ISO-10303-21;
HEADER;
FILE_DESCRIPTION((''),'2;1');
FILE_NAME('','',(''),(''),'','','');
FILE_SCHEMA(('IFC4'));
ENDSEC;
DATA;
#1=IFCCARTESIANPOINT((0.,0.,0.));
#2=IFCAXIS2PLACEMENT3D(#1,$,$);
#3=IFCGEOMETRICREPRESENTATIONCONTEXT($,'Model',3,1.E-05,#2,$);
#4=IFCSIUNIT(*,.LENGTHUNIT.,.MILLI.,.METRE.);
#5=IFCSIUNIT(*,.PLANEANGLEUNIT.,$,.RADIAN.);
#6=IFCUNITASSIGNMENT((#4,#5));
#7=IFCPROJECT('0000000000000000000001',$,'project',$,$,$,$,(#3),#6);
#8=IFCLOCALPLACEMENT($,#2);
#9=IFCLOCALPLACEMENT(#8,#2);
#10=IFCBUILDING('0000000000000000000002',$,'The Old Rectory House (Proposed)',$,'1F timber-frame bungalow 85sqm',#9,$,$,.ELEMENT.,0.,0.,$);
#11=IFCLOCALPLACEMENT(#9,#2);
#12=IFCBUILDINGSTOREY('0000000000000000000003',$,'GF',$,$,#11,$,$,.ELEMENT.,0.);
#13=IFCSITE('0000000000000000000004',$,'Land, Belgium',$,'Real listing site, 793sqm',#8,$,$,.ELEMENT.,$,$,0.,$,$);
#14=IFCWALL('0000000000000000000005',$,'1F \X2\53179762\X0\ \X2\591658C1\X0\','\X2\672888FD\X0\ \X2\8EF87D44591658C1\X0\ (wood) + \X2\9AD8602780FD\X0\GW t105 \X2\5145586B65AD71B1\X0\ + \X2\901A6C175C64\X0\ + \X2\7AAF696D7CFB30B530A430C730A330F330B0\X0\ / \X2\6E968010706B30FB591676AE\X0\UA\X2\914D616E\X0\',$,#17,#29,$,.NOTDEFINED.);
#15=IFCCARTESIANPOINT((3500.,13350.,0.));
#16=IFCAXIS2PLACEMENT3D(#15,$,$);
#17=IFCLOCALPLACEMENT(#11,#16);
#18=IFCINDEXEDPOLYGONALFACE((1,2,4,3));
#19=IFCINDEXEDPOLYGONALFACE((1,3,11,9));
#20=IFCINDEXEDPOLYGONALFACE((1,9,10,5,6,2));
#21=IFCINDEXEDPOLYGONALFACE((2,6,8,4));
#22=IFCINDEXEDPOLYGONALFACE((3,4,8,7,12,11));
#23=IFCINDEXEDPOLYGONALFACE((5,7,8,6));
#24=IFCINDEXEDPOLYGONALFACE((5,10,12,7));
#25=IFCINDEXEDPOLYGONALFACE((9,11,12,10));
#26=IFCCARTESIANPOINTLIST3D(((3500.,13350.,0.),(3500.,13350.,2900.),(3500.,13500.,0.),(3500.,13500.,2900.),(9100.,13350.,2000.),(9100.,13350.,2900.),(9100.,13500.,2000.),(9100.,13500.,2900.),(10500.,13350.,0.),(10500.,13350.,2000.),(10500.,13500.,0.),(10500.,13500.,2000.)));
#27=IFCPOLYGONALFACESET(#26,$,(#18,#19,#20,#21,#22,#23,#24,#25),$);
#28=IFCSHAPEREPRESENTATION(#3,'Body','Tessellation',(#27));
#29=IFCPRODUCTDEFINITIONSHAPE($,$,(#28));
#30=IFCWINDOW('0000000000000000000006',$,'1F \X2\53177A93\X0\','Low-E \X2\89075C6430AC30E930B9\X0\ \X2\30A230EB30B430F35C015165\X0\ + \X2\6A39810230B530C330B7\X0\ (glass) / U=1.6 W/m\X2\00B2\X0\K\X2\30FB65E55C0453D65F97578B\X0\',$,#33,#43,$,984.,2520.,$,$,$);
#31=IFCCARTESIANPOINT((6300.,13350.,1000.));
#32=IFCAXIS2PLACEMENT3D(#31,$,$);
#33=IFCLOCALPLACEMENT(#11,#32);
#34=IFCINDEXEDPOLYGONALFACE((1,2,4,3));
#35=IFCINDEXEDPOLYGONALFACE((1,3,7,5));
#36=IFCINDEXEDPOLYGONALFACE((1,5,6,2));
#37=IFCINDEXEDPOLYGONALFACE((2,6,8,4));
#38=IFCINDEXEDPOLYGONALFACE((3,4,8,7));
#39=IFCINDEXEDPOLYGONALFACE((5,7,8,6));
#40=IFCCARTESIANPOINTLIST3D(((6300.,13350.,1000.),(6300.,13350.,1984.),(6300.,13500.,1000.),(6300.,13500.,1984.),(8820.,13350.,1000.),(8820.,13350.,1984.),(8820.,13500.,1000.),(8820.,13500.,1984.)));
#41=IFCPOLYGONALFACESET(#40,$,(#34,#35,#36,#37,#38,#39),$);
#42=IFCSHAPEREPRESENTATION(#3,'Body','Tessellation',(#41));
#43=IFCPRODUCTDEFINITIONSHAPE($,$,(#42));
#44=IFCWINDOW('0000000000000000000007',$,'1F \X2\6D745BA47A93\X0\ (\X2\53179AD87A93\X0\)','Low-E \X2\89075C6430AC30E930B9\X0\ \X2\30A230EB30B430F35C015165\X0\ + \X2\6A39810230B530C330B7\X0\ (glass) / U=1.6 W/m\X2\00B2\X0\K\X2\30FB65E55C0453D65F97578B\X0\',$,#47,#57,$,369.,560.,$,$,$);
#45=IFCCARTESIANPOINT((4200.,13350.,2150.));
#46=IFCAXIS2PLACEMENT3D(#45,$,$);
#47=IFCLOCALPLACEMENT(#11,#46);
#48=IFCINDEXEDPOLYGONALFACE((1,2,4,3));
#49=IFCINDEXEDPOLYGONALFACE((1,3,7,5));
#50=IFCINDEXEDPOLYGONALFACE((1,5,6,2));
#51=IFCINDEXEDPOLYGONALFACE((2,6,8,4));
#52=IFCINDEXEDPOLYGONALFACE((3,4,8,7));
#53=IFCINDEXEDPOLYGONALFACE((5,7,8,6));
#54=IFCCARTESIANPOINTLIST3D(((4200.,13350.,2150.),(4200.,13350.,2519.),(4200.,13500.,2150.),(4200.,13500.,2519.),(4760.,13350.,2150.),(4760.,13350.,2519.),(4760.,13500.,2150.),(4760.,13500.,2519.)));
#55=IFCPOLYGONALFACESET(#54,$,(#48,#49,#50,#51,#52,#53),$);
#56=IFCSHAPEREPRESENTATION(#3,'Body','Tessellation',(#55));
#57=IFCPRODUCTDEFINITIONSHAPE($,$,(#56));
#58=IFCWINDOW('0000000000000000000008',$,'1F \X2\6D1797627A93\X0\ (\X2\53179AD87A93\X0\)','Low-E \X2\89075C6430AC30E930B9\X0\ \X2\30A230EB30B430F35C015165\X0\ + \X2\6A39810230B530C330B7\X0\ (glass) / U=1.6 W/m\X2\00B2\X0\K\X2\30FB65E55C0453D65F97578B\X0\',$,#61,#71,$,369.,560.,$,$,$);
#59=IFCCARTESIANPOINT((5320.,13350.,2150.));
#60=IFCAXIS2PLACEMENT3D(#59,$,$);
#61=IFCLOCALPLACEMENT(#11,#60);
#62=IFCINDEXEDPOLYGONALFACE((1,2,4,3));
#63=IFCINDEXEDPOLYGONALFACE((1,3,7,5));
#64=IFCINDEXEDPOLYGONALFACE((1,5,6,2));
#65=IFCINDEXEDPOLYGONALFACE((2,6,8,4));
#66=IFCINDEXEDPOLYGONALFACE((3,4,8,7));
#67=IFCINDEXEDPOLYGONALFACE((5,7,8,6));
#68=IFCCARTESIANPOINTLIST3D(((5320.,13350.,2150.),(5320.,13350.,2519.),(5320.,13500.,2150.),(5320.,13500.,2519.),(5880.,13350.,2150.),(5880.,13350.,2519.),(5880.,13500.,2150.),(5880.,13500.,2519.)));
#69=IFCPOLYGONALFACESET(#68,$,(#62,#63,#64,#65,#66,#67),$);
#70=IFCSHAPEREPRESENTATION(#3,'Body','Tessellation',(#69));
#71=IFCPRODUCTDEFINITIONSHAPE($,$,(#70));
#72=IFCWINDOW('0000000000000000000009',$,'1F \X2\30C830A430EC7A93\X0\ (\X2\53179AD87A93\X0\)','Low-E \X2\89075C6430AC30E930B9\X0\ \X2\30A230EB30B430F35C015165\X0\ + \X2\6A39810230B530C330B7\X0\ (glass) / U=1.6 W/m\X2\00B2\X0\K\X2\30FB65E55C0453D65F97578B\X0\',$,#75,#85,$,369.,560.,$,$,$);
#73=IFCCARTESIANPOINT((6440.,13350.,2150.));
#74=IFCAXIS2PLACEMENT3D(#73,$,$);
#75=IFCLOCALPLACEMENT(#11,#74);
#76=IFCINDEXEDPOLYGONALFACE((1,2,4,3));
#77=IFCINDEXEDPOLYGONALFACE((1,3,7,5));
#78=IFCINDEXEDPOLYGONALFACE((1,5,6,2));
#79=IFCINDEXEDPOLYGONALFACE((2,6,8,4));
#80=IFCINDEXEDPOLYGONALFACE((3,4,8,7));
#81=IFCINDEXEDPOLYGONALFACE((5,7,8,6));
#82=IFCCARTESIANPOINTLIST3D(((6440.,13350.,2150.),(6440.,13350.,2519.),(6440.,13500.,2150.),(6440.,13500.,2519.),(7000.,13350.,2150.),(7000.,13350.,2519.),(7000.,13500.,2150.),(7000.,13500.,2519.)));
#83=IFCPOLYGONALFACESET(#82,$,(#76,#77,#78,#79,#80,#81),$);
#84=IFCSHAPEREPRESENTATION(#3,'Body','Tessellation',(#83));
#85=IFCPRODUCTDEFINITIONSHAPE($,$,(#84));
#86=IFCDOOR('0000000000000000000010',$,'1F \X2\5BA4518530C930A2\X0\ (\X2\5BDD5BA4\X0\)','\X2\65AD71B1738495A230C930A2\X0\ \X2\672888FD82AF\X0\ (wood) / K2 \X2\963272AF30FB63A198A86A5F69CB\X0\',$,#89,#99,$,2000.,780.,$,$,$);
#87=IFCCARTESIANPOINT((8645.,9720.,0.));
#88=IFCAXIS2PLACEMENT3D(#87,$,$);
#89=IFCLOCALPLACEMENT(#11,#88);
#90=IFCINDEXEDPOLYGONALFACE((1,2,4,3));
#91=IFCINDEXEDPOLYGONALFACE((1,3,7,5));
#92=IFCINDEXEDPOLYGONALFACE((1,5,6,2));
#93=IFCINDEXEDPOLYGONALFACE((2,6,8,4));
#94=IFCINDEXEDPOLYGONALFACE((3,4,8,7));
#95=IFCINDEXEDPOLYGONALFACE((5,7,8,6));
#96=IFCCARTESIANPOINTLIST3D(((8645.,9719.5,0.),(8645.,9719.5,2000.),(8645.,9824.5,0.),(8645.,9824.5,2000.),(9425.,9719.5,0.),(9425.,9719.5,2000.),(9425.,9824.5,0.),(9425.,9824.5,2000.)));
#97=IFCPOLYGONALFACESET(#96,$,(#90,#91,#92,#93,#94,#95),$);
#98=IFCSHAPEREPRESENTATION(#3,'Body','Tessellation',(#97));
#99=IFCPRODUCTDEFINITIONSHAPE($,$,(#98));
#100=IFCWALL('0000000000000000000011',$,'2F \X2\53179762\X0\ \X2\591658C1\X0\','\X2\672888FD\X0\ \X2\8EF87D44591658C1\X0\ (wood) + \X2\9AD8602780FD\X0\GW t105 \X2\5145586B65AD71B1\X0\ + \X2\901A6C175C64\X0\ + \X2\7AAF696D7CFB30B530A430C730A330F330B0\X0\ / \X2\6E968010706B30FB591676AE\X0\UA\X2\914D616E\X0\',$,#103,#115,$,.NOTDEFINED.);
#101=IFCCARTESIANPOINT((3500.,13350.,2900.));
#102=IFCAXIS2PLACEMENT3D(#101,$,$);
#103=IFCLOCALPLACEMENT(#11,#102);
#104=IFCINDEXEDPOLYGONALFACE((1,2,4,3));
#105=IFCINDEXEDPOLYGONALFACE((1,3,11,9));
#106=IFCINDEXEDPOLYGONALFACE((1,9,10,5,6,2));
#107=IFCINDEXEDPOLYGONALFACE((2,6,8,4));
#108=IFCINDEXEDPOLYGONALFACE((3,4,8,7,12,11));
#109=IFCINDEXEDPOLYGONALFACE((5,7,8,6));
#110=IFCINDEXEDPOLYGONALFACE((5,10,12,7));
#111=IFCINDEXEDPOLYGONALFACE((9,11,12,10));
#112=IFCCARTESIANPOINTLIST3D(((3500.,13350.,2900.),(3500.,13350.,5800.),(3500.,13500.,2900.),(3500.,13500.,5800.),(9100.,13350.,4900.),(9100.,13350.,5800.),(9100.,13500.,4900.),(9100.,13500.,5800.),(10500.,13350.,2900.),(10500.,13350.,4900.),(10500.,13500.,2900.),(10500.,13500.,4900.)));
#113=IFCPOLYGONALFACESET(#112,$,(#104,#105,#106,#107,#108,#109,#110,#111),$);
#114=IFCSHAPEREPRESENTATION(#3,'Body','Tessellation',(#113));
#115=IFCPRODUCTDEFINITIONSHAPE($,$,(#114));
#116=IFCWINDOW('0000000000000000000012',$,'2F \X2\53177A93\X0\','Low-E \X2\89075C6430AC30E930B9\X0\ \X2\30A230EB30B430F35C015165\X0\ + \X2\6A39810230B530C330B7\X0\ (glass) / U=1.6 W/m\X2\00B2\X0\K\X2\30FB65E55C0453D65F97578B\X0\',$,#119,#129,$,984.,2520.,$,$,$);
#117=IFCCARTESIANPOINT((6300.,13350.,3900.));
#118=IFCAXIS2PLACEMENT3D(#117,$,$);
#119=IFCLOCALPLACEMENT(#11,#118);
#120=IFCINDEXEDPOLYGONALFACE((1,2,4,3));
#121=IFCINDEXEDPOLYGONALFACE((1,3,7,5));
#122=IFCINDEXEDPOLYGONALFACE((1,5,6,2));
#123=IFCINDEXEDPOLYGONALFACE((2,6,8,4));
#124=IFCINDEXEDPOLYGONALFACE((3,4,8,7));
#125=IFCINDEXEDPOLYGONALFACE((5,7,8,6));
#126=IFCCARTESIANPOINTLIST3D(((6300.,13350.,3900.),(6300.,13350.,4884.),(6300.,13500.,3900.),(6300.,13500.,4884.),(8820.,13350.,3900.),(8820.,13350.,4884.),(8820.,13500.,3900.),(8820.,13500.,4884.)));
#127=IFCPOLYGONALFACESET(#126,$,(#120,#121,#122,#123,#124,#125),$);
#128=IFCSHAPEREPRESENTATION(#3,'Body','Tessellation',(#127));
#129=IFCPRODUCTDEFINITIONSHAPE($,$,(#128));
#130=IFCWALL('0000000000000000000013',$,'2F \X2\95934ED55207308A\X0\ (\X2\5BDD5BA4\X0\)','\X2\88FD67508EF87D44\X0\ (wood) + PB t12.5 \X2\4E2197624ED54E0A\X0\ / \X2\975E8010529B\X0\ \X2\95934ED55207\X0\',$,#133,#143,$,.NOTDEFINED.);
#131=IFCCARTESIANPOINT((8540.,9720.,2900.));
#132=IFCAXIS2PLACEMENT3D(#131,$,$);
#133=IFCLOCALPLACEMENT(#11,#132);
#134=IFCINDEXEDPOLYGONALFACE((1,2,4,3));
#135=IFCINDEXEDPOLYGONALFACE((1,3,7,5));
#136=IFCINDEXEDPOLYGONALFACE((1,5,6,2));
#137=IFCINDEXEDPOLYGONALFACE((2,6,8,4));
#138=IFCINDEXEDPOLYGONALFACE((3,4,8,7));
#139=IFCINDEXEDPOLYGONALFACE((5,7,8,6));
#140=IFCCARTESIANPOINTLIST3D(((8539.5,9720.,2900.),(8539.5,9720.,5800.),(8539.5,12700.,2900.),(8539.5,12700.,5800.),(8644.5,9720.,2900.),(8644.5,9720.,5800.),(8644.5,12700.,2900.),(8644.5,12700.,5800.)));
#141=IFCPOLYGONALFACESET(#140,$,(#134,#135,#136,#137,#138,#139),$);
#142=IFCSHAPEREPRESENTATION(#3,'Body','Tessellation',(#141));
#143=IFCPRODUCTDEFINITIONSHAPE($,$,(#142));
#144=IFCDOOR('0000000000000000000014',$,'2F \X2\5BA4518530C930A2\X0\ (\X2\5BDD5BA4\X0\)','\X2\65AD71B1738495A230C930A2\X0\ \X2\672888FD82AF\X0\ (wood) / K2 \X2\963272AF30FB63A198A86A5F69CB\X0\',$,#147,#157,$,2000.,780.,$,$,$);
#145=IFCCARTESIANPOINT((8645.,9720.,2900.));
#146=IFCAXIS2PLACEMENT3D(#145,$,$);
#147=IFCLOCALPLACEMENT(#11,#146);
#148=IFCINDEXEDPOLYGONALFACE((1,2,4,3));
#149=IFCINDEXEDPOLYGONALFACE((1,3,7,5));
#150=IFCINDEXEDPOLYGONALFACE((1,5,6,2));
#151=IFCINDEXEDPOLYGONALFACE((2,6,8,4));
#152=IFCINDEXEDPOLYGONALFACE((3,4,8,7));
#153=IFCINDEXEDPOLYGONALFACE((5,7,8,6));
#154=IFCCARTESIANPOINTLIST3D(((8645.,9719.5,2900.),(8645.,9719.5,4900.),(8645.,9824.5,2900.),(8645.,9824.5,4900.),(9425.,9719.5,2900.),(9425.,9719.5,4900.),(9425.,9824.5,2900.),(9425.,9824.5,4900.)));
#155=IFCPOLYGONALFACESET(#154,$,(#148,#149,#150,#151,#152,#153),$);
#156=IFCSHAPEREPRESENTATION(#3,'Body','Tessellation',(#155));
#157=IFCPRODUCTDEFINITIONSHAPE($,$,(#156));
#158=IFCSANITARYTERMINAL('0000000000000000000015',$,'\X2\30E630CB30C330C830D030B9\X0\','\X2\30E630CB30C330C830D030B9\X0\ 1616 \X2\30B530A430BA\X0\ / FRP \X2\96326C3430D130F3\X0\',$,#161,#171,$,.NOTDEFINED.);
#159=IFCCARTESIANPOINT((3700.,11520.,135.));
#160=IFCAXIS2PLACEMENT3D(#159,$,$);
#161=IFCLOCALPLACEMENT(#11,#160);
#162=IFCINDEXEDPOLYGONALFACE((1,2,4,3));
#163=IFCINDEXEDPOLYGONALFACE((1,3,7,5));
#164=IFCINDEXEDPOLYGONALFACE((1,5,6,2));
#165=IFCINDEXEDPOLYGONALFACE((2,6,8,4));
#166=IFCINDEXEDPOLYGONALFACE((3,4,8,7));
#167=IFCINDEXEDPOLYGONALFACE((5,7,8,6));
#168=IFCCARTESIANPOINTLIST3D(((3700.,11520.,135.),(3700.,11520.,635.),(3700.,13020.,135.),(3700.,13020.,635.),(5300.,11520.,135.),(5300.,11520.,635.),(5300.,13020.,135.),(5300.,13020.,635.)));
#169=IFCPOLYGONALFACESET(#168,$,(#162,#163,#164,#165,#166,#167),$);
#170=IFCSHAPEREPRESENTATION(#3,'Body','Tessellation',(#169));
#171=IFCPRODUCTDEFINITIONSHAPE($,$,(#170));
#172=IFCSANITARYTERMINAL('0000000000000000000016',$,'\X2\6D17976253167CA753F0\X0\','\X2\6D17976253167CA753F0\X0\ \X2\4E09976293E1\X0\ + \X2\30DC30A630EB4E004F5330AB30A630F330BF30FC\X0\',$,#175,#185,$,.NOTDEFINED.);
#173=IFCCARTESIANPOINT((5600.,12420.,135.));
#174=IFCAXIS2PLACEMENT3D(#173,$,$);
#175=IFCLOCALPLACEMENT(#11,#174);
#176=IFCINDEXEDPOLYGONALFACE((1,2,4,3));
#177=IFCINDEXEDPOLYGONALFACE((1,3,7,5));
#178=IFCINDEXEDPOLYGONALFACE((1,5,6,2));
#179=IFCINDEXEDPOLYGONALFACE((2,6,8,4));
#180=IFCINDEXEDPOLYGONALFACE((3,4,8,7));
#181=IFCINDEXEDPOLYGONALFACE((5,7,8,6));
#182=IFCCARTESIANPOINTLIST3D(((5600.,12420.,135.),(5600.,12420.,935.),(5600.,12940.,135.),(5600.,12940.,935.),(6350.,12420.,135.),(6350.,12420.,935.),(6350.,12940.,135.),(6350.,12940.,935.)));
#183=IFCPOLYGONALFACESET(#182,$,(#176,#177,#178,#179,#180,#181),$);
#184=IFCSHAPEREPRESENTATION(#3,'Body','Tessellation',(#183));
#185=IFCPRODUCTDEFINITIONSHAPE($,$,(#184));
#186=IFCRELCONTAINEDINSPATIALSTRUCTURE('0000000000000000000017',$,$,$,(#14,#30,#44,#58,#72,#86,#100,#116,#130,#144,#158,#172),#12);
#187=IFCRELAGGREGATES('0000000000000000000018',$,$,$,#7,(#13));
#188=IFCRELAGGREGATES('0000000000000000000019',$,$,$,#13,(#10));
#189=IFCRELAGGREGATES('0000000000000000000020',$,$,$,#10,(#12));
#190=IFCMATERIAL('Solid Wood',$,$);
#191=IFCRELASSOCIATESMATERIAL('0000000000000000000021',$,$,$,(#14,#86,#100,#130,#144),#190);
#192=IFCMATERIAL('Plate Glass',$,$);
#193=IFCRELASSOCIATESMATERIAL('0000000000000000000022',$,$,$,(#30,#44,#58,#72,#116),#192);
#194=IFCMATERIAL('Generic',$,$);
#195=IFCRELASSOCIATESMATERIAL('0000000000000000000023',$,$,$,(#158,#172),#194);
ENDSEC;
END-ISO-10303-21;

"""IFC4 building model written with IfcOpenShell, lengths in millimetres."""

from ifc_helpers import new_model, si_unit, frame, frame_2d, origin, place, context, project, spatial, rectangle, extrude, material, element, fill, save


model = new_model("IFC4")

# Units and contexts
model_context = context("Model", 3, precision=1e-05, world=origin())
ifc_project = project(units=[si_unit("LENGTHUNIT", "METRE", prefix="MILLI"), si_unit("PLANEANGLEUNIT", "RADIAN")], contexts=[model_context])

# Site, building, storey
site_placement = place(None, origin())
site = spatial("IfcSite", under=ifc_project, at=site_placement, Name="Land, Belgium", ObjectType="Real listing site, 793sqm", CompositionType="ELEMENT", RefElevation=0.0)
building_placement = place(site_placement, origin())
building = spatial("IfcBuilding", under=site, at=building_placement, Name="The Old Rectory House (Proposed)", ObjectType="1F timber-frame bungalow 85sqm", CompositionType="ELEMENT", ElevationOfRefHeight=0.0, ElevationOfTerrain=0.0)
storey_placement = place(building_placement, origin())
storey = spatial("IfcBuildingStorey", under=building, at=storey_placement, Name="GF", CompositionType="ELEMENT", Elevation=0.0)

# Wall, openings, windows
ifc_material_1 = material(Name="Solid Wood")
wall_1_placement = place(storey_placement, frame((3500.0, 13350.0, 0.0)))
wall_1 = element("IfcWall", 1, at=wall_1_placement, inside=storey, material=ifc_material_1, Name="1F 北面 外壁", Description="木製 軸組外壁 (wood) + 高性能GW t105 充填断熱 + 通気層 + 窯業系サイディング / 準耐火・外皮UA配慮", PredefinedType="NOTDEFINED", context=model_context, shape_type="SweptSolid", body=[
    extrude(rectangle(XDim=7000.0, YDim=150.0, at=frame_2d((3500.0, 75.0))), frame((3500.0, 13350.0, 0.0)), (0.0, 0.0, 1.0), 2900.0),
])
opening_1_placement = place(storey_placement, frame((6300.0, 13350.0, 1000.0)))
opening_1 = element("IfcOpeningElement", 2, at=opening_1_placement, cuts=wall_1, PredefinedType="NOTDEFINED", context=model_context, shape_type="SweptSolid", body=[
    extrude(rectangle(XDim=2520.0, YDim=150.0, at=frame_2d((1260.0, 75.0))), frame((6300.0, 13350.0, 1000.0)), (0.0, 0.0, 1.0), 984.0),
])
opening_2_placement = place(storey_placement, frame((4200.0, 13350.0, 2150.0)))
opening_2 = element("IfcOpeningElement", 3, at=opening_2_placement, cuts=wall_1, PredefinedType="NOTDEFINED", context=model_context, shape_type="SweptSolid", body=[
    extrude(rectangle(XDim=560.0, YDim=150.0, at=frame_2d((280.0, 75.0))), frame((4200.0, 13350.0, 2150.0)), (0.0, 0.0, 1.0), 369.0),
])
opening_3_placement = place(storey_placement, frame((5320.0, 13350.0, 2150.0)))
opening_3 = element("IfcOpeningElement", 4, at=opening_3_placement, cuts=wall_1, PredefinedType="NOTDEFINED", context=model_context, shape_type="SweptSolid", body=[
    extrude(rectangle(XDim=560.0, YDim=150.0, at=frame_2d((280.0, 75.0))), frame((5320.0, 13350.0, 2150.0)), (0.0, 0.0, 1.0), 369.0),
])
opening_4_placement = place(storey_placement, frame((6440.0, 13350.0, 2150.0)))
opening_4 = element("IfcOpeningElement", 5, at=opening_4_placement, cuts=wall_1, PredefinedType="NOTDEFINED", context=model_context, shape_type="SweptSolid", body=[
    extrude(rectangle(XDim=560.0, YDim=150.0, at=frame_2d((280.0, 75.0))), frame((6440.0, 13350.0, 2150.0)), (0.0, 0.0, 1.0), 369.0),
])
ifc_material_2 = material(Name="Plate Glass")
window_1_placement = place(storey_placement, frame((6300.0, 13350.0, 1000.0)))
window_1 = element("IfcWindow", 6, at=window_1_placement, inside=storey, material=ifc_material_2, Name="1F 北窓", Description="Low-E 複層ガラス アルゴン封入 + 樹脂サッシ (glass) / U=1.6 W/m²K・日射取得型", OverallHeight=984.0, OverallWidth=2520.0, context=model_context, shape_type="SweptSolid", body=[
    extrude(rectangle(XDim=2520.0, YDim=150.0, at=frame_2d((1260.0, 75.0))), frame((6300.0, 13350.0, 1000.0)), (0.0, 0.0, 1.0), 984.0),
])
fill(opening_1, window_1)
window_2_placement = place(storey_placement, frame((4200.0, 13350.0, 2150.0)))
window_2 = element("IfcWindow", 7, at=window_2_placement, inside=storey, material=ifc_material_2, Name="1F 浴室窓 (北高窓)", Description="Low-E 複層ガラス アルゴン封入 + 樹脂サッシ (glass) / U=1.6 W/m²K・日射取得型", OverallHeight=369.0, OverallWidth=560.0, context=model_context, shape_type="SweptSolid", body=[
    extrude(rectangle(XDim=560.0, YDim=150.0, at=frame_2d((280.0, 75.0))), frame((4200.0, 13350.0, 2150.0)), (0.0, 0.0, 1.0), 369.0),
])
fill(opening_2, window_2)
window_3_placement = place(storey_placement, frame((5320.0, 13350.0, 2150.0)))
window_3 = element("IfcWindow", 8, at=window_3_placement, inside=storey, material=ifc_material_2, Name="1F 洗面窓 (北高窓)", Description="Low-E 複層ガラス アルゴン封入 + 樹脂サッシ (glass) / U=1.6 W/m²K・日射取得型", OverallHeight=369.0, OverallWidth=560.0, context=model_context, shape_type="SweptSolid", body=[
    extrude(rectangle(XDim=560.0, YDim=150.0, at=frame_2d((280.0, 75.0))), frame((5320.0, 13350.0, 2150.0)), (0.0, 0.0, 1.0), 369.0),
])
fill(opening_3, window_3)
window_4_placement = place(storey_placement, frame((6440.0, 13350.0, 2150.0)))
window_4 = element("IfcWindow", 9, at=window_4_placement, inside=storey, material=ifc_material_2, Name="1F トイレ窓 (北高窓)", Description="Low-E 複層ガラス アルゴン封入 + 樹脂サッシ (glass) / U=1.6 W/m²K・日射取得型", OverallHeight=369.0, OverallWidth=560.0, context=model_context, shape_type="SweptSolid", body=[
    extrude(rectangle(XDim=560.0, YDim=150.0, at=frame_2d((280.0, 75.0))), frame((6440.0, 13350.0, 2150.0)), (0.0, 0.0, 1.0), 369.0),
])
fill(opening_4, window_4)

# Door
door_1_placement = place(storey_placement, frame((8645.0, 9720.0, 0.0)))
element("IfcDoor", 10, at=door_1_placement, inside=storey, material=ifc_material_1, Name="1F 室内ドア (寝室)", Description="断熱玄関ドア 木製芯 (wood) / K2 防犯・採風機構", OverallHeight=2000.0, OverallWidth=780.0, context=model_context, shape_type="SweptSolid", body=[
    extrude(rectangle(XDim=780.0, YDim=105.0, at=frame_2d((390.0, 52.0))), frame((8645.0, 9720.0, 0.0)), (0.0, 0.0, 1.0), 2000.0),
])

# Wall, opening, window
wall_2_placement = place(storey_placement, frame((3500.0, 13350.0, 2900.0)))
wall_2 = element("IfcWall", 11, at=wall_2_placement, inside=storey, material=ifc_material_1, Name="2F 北面 外壁", Description="木製 軸組外壁 (wood) + 高性能GW t105 充填断熱 + 通気層 + 窯業系サイディング / 準耐火・外皮UA配慮", PredefinedType="NOTDEFINED", context=model_context, shape_type="SweptSolid", body=[
    extrude(rectangle(XDim=7000.0, YDim=150.0, at=frame_2d((3500.0, 75.0))), frame((3500.0, 13350.0, 2900.0)), (0.0, 0.0, 1.0), 2900.0),
])
opening_5_placement = place(storey_placement, frame((6300.0, 13350.0, 3900.0)))
opening_5 = element("IfcOpeningElement", 12, at=opening_5_placement, cuts=wall_2, PredefinedType="NOTDEFINED", context=model_context, shape_type="SweptSolid", body=[
    extrude(rectangle(XDim=2520.0, YDim=150.0, at=frame_2d((1260.0, 75.0))), frame((6300.0, 13350.0, 3900.0)), (0.0, 0.0, 1.0), 984.0),
])
window_5_placement = place(storey_placement, frame((6300.0, 13350.0, 3900.0)))
window_5 = element("IfcWindow", 13, at=window_5_placement, inside=storey, material=ifc_material_2, Name="2F 北窓", Description="Low-E 複層ガラス アルゴン封入 + 樹脂サッシ (glass) / U=1.6 W/m²K・日射取得型", OverallHeight=984.0, OverallWidth=2520.0, context=model_context, shape_type="SweptSolid", body=[
    extrude(rectangle(XDim=2520.0, YDim=150.0, at=frame_2d((1260.0, 75.0))), frame((6300.0, 13350.0, 3900.0)), (0.0, 0.0, 1.0), 984.0),
])
fill(opening_5, window_5)

# Wall
wall_3_placement = place(storey_placement, frame((8540.0, 9720.0, 2900.0)))
element("IfcWall", 14, at=wall_3_placement, inside=storey, material=ifc_material_1, Name="2F 間仕切り (寝室)", Description="製材軸組 (wood) + PB t12.5 両面仕上 / 非耐力 間仕切", PredefinedType="NOTDEFINED", context=model_context, shape_type="SweptSolid", body=[
    extrude(rectangle(XDim=105.0, YDim=2980.0, at=frame_2d((52.0, 1490.0))), frame((8540.0, 9720.0, 2900.0)), (0.0, 0.0, 1.0), 2900.0),
])

# Door
door_2_placement = place(storey_placement, frame((8645.0, 9720.0, 2900.0)))
element("IfcDoor", 15, at=door_2_placement, inside=storey, material=ifc_material_1, Name="2F 室内ドア (寝室)", Description="断熱玄関ドア 木製芯 (wood) / K2 防犯・採風機構", OverallHeight=2000.0, OverallWidth=780.0, context=model_context, shape_type="SweptSolid", body=[
    extrude(rectangle(XDim=780.0, YDim=105.0, at=frame_2d((390.0, 52.0))), frame((8645.0, 9720.0, 2900.0)), (0.0, 0.0, 1.0), 2000.0),
])

# Sanitary terminals
ifc_material_3 = material(Name="Generic")
sanitary_terminal_1_placement = place(storey_placement, frame((3700.0, 11520.0, 135.0)))
element("IfcSanitaryTerminal", 16, at=sanitary_terminal_1_placement, inside=storey, material=ifc_material_3, Name="ユニットバス", Description="ユニットバス 1616 サイズ / FRP 防水パン", PredefinedType="NOTDEFINED", context=model_context, shape_type="SweptSolid", body=[
    extrude(rectangle(XDim=1600.0, YDim=1500.0, at=frame_2d((800.0, 750.0))), frame((3700.0, 11520.0, 135.0)), (0.0, 0.0, 1.0), 500.0),
])
sanitary_terminal_2_placement = place(storey_placement, frame((5600.0, 12420.0, 135.0)))
element("IfcSanitaryTerminal", 17, at=sanitary_terminal_2_placement, inside=storey, material=ifc_material_3, Name="洗面化粧台", Description="洗面化粧台 三面鏡 + ボウル一体カウンター", PredefinedType="NOTDEFINED", context=model_context, shape_type="SweptSolid", body=[
    extrude(rectangle(XDim=750.0, YDim=520.0, at=frame_2d((375.0, 260.0))), frame((5600.0, 12420.0, 135.0)), (0.0, 0.0, 1.0), 800.0),
])

save(model, "model.ifc")
